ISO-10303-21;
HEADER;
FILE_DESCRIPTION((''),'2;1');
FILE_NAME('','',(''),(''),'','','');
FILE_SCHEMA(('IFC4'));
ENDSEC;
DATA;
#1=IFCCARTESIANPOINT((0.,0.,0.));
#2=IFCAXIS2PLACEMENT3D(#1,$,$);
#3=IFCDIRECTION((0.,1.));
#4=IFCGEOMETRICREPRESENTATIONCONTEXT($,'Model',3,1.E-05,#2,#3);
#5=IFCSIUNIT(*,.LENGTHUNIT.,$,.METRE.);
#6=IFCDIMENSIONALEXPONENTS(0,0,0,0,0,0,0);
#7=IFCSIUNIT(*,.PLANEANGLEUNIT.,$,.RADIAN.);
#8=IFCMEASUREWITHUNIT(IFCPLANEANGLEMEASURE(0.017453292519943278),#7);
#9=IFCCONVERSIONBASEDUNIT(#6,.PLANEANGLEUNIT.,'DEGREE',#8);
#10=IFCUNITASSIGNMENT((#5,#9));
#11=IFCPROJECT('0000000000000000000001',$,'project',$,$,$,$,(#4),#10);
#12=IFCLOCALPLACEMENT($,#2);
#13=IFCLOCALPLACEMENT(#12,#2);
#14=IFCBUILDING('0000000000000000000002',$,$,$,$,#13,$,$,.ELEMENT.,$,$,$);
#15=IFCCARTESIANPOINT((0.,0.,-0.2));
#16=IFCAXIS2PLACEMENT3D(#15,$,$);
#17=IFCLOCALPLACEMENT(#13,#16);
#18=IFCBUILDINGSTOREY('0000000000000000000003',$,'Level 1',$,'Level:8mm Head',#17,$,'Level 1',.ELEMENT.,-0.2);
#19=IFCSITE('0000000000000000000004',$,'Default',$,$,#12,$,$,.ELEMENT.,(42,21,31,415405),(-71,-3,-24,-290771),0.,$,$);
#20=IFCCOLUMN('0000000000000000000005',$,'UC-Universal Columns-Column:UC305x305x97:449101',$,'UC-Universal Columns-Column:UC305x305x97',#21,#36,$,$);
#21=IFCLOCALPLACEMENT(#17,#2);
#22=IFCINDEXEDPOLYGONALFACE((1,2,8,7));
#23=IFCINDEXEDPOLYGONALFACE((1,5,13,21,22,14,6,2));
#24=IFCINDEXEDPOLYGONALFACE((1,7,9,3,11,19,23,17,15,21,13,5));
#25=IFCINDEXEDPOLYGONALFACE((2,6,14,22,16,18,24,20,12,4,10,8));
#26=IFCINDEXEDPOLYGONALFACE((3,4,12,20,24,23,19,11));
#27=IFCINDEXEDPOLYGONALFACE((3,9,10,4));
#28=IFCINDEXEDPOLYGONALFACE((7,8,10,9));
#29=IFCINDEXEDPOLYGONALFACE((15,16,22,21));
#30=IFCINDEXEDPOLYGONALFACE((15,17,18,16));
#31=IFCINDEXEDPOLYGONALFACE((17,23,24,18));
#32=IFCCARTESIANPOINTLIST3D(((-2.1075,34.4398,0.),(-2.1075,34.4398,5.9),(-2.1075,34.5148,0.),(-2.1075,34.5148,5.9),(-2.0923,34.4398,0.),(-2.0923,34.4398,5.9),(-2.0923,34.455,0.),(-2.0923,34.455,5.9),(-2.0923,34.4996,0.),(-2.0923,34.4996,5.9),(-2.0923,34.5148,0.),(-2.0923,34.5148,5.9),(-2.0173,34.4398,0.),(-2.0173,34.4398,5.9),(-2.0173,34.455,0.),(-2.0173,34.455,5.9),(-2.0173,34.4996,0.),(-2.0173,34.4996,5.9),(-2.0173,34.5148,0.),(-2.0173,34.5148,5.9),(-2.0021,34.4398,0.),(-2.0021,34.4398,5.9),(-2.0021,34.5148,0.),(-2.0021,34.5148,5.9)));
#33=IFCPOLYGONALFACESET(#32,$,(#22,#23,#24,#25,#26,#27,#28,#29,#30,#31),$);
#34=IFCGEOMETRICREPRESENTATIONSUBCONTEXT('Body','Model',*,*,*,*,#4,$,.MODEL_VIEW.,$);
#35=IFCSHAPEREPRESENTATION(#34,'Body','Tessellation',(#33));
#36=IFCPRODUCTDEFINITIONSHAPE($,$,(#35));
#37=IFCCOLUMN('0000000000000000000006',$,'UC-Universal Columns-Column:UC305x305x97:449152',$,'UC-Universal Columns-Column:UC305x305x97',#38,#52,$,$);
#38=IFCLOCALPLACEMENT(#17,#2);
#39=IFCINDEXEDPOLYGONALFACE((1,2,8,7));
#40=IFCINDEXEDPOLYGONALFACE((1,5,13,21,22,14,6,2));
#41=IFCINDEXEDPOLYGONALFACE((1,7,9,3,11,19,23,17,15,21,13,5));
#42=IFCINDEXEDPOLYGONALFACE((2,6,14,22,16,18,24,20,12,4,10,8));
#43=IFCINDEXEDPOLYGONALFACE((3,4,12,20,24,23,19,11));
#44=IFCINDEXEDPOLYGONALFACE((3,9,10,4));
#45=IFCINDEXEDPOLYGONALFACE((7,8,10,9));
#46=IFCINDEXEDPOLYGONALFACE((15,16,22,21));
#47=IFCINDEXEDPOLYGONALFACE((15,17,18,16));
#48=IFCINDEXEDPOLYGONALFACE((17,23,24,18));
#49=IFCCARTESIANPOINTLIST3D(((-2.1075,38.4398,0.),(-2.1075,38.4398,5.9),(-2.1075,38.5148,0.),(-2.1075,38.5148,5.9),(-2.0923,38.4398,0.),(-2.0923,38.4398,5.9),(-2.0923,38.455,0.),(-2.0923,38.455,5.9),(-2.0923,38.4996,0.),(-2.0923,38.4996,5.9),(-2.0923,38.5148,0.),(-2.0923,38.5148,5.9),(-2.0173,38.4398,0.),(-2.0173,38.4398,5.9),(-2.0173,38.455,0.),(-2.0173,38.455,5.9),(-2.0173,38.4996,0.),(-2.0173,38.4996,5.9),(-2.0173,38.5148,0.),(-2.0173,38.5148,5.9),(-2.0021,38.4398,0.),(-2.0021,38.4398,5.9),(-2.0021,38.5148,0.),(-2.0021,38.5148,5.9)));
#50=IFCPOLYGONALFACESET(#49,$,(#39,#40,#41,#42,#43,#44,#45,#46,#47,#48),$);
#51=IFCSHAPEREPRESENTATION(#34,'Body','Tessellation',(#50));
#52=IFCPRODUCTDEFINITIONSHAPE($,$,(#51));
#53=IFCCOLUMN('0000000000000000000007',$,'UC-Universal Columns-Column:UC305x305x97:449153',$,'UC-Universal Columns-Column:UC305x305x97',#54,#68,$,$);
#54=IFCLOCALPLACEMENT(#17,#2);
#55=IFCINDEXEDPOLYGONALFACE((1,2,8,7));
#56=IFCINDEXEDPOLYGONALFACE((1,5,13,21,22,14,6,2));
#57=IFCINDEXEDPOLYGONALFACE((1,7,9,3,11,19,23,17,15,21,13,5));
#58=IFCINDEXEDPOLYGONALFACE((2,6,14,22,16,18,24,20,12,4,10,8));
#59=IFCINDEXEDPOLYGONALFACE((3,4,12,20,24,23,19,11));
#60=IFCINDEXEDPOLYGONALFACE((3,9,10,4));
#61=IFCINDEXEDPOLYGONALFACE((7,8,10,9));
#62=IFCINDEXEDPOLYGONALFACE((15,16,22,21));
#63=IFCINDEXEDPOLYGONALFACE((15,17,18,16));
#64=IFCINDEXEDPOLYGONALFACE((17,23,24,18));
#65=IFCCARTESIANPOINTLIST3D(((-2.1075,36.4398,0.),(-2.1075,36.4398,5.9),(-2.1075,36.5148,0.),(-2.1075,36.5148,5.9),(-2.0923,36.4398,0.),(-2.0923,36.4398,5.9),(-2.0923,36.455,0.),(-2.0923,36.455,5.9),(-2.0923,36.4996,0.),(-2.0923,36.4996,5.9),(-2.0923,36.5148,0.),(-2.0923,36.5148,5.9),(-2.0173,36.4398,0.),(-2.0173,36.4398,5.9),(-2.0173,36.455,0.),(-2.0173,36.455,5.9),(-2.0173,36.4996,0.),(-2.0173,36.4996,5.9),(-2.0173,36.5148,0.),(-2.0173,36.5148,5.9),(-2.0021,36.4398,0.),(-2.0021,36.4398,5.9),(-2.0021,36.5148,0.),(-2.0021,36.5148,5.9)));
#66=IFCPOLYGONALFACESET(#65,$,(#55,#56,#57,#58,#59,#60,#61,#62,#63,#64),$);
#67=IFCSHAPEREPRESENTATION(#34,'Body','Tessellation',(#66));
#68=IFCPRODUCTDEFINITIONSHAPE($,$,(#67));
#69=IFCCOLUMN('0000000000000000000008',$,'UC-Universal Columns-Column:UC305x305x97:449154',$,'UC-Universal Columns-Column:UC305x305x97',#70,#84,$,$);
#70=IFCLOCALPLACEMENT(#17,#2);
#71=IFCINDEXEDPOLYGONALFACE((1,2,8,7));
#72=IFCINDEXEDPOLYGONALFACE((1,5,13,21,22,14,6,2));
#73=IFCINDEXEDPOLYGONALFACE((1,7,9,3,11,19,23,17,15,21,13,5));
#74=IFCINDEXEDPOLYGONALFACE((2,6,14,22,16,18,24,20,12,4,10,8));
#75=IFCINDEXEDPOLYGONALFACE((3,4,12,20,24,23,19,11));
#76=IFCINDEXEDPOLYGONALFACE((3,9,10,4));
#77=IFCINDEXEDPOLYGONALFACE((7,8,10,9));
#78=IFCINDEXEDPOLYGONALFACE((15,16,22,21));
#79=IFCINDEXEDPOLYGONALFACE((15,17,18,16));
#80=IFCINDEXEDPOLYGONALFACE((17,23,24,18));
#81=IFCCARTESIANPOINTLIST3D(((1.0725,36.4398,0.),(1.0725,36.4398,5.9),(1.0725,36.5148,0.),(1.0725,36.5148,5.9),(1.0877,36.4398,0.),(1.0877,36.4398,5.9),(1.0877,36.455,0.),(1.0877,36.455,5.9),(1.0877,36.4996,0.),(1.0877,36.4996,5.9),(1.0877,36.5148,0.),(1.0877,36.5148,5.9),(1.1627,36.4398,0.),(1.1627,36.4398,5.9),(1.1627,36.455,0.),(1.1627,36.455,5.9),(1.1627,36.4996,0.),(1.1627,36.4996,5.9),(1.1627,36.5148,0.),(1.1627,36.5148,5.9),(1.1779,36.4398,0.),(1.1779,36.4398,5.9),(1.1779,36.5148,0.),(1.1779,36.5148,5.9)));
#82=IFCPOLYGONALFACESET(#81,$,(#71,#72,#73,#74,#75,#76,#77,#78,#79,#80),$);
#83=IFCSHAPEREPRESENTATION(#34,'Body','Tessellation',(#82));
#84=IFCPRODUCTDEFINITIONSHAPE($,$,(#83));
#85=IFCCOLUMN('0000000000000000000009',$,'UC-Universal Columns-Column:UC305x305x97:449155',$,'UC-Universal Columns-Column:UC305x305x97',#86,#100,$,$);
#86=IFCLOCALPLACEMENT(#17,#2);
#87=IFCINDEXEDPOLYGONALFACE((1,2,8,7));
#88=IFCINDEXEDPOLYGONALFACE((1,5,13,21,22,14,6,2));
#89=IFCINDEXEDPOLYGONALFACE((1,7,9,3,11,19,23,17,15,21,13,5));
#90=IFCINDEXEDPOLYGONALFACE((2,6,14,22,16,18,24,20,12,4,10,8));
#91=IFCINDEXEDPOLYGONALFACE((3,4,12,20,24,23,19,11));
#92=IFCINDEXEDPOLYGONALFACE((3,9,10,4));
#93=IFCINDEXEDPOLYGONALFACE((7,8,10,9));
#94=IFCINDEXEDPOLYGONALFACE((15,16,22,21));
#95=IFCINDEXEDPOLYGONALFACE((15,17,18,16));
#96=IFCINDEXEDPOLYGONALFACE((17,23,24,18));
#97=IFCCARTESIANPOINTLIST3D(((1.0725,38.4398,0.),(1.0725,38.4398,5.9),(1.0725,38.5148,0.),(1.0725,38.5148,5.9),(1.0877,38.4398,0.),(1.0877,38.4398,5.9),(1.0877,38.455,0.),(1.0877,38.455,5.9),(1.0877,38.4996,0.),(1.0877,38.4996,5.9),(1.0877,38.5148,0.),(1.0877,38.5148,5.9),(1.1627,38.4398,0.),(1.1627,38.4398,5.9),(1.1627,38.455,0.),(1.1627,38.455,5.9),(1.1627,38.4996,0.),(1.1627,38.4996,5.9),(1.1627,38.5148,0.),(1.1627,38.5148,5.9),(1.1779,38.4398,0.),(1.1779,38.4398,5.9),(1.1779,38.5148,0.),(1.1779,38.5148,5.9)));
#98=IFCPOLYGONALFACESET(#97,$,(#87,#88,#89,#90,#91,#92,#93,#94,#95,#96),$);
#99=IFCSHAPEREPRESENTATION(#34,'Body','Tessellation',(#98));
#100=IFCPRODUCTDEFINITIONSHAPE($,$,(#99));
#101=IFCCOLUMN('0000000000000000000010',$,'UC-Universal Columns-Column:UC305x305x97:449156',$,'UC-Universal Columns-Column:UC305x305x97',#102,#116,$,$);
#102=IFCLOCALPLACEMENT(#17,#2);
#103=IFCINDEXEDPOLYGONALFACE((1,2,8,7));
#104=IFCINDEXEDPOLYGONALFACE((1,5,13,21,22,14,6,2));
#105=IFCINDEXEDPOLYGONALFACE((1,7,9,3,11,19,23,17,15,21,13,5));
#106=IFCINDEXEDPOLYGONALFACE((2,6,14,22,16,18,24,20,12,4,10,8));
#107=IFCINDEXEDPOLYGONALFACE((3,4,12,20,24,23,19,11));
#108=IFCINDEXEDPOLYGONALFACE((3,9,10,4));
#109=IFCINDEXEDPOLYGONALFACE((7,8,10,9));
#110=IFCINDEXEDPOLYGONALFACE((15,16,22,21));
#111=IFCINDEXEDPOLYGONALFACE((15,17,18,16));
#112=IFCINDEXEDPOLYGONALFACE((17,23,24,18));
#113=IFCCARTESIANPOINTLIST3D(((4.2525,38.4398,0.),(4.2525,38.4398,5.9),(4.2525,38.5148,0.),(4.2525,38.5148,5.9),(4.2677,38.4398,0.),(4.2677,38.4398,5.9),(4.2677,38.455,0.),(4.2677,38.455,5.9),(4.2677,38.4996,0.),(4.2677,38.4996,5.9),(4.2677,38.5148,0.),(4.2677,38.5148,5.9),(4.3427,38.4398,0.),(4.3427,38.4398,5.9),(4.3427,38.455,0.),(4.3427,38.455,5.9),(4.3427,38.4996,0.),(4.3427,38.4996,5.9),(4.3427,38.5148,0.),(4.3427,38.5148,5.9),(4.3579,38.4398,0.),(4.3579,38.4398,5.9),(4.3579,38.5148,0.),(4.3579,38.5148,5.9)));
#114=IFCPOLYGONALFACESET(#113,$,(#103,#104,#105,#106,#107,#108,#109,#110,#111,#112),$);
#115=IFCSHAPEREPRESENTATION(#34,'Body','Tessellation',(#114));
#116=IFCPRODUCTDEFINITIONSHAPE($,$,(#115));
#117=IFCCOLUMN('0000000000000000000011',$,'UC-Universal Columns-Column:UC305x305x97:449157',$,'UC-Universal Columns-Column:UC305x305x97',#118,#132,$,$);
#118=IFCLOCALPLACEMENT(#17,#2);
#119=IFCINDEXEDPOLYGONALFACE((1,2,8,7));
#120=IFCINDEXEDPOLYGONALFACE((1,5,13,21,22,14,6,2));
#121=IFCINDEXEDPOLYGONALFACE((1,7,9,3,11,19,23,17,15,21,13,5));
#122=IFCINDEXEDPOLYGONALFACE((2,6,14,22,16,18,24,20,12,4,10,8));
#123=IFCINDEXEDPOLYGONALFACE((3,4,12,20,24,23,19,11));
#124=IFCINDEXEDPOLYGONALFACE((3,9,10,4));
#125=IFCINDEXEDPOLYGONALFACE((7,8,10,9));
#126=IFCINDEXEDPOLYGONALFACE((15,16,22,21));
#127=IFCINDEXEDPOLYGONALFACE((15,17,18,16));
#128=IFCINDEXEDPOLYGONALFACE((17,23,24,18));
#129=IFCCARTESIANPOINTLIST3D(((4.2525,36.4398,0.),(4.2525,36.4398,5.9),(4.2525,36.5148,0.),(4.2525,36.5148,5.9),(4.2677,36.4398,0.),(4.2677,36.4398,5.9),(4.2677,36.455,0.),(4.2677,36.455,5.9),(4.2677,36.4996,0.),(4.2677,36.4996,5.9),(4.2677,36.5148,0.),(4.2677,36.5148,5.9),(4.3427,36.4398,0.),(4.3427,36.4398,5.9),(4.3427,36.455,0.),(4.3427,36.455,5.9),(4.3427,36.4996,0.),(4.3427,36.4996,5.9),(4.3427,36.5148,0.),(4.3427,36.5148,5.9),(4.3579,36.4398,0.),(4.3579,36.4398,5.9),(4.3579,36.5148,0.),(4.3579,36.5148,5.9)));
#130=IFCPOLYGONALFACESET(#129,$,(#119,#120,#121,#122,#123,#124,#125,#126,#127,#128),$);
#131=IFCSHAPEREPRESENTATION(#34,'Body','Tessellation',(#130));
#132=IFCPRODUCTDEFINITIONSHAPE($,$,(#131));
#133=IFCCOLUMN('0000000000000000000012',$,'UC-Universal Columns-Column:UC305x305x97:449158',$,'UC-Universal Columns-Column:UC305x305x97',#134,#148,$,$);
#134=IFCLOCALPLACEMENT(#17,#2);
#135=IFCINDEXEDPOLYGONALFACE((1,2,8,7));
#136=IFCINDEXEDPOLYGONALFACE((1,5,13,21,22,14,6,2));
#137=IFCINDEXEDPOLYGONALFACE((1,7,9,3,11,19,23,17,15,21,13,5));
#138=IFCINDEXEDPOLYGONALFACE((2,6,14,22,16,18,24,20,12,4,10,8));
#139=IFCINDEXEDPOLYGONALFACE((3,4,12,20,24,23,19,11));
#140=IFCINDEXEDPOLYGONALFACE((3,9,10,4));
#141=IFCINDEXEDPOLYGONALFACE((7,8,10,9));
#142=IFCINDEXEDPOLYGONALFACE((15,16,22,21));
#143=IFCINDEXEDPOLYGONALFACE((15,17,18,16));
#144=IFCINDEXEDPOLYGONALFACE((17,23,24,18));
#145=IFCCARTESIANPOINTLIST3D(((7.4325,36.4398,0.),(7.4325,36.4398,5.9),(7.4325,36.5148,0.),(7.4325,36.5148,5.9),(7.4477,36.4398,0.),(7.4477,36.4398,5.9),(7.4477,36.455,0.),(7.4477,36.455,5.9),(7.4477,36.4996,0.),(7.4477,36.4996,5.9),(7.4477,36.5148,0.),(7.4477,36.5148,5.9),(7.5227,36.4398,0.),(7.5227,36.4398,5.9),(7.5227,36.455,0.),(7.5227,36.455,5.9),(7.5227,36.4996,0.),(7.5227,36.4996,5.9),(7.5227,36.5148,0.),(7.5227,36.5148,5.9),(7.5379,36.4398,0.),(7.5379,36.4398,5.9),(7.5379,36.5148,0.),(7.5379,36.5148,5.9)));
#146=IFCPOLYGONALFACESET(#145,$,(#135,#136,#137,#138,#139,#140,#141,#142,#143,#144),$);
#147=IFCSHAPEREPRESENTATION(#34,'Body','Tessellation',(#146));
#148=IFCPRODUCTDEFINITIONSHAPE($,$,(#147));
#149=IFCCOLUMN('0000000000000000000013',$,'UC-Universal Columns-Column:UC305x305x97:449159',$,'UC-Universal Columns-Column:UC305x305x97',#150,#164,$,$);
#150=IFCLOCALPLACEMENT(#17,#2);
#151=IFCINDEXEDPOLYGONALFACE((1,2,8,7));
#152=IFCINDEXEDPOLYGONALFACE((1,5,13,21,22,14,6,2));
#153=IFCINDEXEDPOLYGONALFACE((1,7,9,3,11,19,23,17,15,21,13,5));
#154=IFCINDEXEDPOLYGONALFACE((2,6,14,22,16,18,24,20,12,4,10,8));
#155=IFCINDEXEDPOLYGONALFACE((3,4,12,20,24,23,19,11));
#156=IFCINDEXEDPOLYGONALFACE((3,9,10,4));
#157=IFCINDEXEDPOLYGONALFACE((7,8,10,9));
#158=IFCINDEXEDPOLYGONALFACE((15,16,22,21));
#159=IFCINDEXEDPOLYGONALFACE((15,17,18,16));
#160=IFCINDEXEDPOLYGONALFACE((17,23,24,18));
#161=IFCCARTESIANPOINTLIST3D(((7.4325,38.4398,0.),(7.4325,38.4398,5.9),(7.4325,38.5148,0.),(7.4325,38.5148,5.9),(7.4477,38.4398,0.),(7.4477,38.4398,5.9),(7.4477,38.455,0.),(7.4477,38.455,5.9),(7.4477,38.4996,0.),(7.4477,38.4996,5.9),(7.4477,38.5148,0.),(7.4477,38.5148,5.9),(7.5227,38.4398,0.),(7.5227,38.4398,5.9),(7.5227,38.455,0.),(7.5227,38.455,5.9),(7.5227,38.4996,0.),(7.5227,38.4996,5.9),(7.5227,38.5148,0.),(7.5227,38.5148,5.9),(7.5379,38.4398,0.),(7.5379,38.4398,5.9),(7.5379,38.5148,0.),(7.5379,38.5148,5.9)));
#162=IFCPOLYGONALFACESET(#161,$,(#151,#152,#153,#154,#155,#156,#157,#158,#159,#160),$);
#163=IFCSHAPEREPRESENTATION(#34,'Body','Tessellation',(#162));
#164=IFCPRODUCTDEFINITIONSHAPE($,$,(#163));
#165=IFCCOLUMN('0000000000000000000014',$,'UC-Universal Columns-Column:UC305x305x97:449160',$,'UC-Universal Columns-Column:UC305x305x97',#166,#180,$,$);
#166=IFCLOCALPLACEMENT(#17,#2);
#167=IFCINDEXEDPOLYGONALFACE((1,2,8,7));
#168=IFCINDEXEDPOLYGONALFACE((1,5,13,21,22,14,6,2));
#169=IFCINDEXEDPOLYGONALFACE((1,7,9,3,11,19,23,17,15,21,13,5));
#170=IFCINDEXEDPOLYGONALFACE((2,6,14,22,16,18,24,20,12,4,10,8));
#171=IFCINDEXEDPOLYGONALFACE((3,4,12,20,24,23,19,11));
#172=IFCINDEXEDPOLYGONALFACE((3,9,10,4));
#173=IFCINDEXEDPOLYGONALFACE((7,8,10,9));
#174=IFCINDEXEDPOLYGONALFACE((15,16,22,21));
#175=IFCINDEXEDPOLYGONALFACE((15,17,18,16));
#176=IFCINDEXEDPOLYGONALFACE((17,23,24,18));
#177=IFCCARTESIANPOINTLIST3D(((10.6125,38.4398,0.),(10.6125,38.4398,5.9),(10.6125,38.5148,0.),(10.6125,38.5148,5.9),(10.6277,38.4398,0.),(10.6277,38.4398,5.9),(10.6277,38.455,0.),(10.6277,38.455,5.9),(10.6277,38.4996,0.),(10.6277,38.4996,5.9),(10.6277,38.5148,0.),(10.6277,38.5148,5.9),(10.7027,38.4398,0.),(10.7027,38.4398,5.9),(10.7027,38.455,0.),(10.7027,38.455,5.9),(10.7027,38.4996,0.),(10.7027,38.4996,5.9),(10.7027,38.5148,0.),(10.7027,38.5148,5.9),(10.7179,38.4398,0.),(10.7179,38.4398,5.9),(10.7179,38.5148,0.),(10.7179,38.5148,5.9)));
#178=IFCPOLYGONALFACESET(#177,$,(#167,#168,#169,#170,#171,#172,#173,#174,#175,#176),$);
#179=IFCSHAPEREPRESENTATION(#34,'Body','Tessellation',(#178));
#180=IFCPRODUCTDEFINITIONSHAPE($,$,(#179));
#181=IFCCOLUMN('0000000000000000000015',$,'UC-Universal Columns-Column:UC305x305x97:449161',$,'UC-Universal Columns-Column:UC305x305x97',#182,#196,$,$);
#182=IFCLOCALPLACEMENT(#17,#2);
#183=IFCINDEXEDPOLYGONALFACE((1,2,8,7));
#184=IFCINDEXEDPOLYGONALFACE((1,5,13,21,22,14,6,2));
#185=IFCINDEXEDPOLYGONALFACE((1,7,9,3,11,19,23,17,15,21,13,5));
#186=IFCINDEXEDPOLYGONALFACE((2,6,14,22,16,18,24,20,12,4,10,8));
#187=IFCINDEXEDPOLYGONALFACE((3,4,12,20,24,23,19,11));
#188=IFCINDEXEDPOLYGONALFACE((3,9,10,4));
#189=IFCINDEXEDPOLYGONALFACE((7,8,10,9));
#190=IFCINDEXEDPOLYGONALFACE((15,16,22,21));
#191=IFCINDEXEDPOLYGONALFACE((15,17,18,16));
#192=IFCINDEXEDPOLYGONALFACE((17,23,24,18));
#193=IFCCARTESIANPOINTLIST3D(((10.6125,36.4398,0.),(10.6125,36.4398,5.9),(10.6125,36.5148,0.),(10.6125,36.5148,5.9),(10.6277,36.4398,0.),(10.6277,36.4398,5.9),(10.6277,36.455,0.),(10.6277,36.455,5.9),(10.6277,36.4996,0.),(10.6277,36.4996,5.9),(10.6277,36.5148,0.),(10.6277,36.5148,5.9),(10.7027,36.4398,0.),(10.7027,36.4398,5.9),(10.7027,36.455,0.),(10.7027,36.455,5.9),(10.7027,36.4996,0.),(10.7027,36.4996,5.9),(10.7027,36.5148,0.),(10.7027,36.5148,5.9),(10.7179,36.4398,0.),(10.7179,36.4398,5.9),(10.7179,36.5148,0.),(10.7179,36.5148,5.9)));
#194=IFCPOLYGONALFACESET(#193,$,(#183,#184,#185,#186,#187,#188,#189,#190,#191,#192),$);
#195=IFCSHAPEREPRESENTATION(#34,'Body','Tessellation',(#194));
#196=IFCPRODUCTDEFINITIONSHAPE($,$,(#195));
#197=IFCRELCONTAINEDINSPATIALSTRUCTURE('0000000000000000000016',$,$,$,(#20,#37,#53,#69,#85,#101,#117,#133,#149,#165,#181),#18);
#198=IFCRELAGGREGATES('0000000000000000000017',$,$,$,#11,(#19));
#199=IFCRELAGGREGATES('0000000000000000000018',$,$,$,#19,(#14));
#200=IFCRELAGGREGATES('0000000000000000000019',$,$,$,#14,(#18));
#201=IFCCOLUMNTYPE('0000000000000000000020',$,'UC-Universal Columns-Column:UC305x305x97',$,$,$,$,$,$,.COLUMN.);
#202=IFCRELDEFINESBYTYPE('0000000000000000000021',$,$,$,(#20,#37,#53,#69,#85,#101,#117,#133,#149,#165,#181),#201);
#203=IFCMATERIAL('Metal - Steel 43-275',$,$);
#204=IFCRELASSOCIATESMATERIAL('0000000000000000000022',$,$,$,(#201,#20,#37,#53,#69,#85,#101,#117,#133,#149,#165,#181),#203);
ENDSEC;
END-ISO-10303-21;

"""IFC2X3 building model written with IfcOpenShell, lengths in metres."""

from ifc_helpers import new_model, entity, si_unit, converted_unit, direction, frame, frame_2d, origin, place, context, subcontext, project, spatial, polyline, circle_curve, parameter, trimmed, segment, composite_curve, outline, extrude, source, transform, mapped, material, type_object, type_shapes, element, save


model = new_model("IFC2X3")

# Units and contexts
model_context = context("Model", 3, precision=1e-05, world=origin(), true_north=direction((0.0, 1.0)))
body_context = subcontext(model_context, "Body", "Model", "MODEL_VIEW")
ifc_project = project(units=[si_unit("LENGTHUNIT", "METRE"), converted_unit("PLANEANGLEUNIT", "DEGREE", entity("IfcPlaneAngleMeasure", 0.017453292519943278), si_unit("PLANEANGLEUNIT", "RADIAN"), dimensions=[0, 0, 0, 0, 0, 0, 0])], contexts=[model_context])

# Site, building, storey
site_placement = place(None, origin())
site = spatial("IfcSite", under=ifc_project, at=site_placement, Name="Default", CompositionType="ELEMENT", RefLatitude=(42, 21, 31, 415405), RefLongitude=(-71, -3, -24, -290771), RefElevation=0.0)
building_placement = place(site_placement, origin())
building = spatial("IfcBuilding", under=site, at=building_placement, CompositionType="ELEMENT")
storey_placement = place(building_placement, frame((0.0, 0.0, -0.2)))
storey = spatial("IfcBuildingStorey", under=building, at=storey_placement, Name="Level 1", ObjectType="Level:8mm Head", LongName="Level 1", CompositionType="ELEMENT", Elevation=-0.2)

# Columns
ifc_material = material(Name="Metal - Steel 43-275")
column_type = type_object("IfcColumnType", Name="UC-Universal Columns-Column:UC305x305x97", PredefinedType="COLUMN", material=ifc_material)
shared_shape = source(origin(), body_context, "Body", "SweptSolid", [
    extrude(outline(composite_curve([segment(polyline([(-0.0375, -0.0375), (0.0375, -0.0375)]), True, "CONTINUOUS"), segment(polyline([(0.0375, -0.0375), (0.0527, -0.0375)]), True, "CONTINUOUS"), segment(trimmed(circle_curve(frame_2d((0.0527, -0.0223), x_axis=(-1.0, 0.0)), 0.0152), [parameter(0.0)], [parameter(90.0)], True, "PARAMETER"), False, "CONTINUOUS"), segment(polyline([(0.0375, -0.0223), (0.0375, 0.0223)]), True, "CONTINUOUS"), segment(trimmed(circle_curve(frame_2d((0.0527, 0.0223), x_axis=(-1.0, 0.0)), 0.0152), [parameter(270.0)], [parameter(0.0)], True, "PARAMETER"), False, "CONTINUOUS"), segment(polyline([(0.0527, 0.0375), (0.0375, 0.0375)]), True, "CONTINUOUS"), segment(polyline([(0.0375, 0.0375), (-0.0375, 0.0375)]), True, "CONTINUOUS"), segment(polyline([(-0.0375, 0.0375), (-0.0527, 0.0375)]), True, "CONTINUOUS"), segment(trimmed(circle_curve(frame_2d((-0.0527, 0.0223), x_axis=(-1.0, 0.0)), 0.0152), [parameter(180.0)], [parameter(270.0)], True, "PARAMETER"), False, "CONTINUOUS"), segment(polyline([(-0.0375, 0.0223), (-0.0375, -0.0223)]), True, "CONTINUOUS"), segment(trimmed(circle_curve(frame_2d((-0.0527, -0.0223), x_axis=(-1.0, 0.0)), 0.0152), [parameter(90.0)], [parameter(180.0)], True, "PARAMETER"), False, "CONTINUOUS"), segment(polyline([(-0.0527, -0.0375), (-0.0375, -0.0375)]), True, "CONTINUOUS")], self_intersect=False)), frame((0.0, 0.0, -0.2), z_axis=(0.0, 0.0, 1.0), x_axis=(-1.0, 0.0, 0.0)), (0.0, 0.0, 1.0), 5.9),
])
type_shapes(column_type, [shared_shape])
for number, where, z_axis, x_axis, name in (
    (1, (-2.0548, 34.4773, 0.2), (0.0, 0.0, 1.0), (-1.0, 0.0, 0.0), "UC-Universal Columns-Column:UC305x305x97:449101"),
    (2, (-2.0548, 38.4773, 0.2), (0.0, 0.0, 1.0), (-1.0, 0.0, 0.0), "UC-Universal Columns-Column:UC305x305x97:449152"),
    (3, (-2.0548, 36.4773, 0.2), (0.0, 0.0, 1.0), (-1.0, 0.0, 0.0), "UC-Universal Columns-Column:UC305x305x97:449153"),
    (4, (1.1252, 36.4773, 0.2), (0.0, 0.0, 1.0), (-1.0, 0.0, 0.0), "UC-Universal Columns-Column:UC305x305x97:449154"),
    (5, (1.1252, 38.4773, 0.2), (0.0, 0.0, 1.0), (-1.0, 0.0, 0.0), "UC-Universal Columns-Column:UC305x305x97:449155"),
    (6, (4.3052, 38.4773, 0.2), (0.0, 0.0, 1.0), (-1.0, 0.0, 0.0), "UC-Universal Columns-Column:UC305x305x97:449156"),
    (7, (4.3052, 36.4773, 0.2), (0.0, 0.0, 1.0), (-1.0, 0.0, 0.0), "UC-Universal Columns-Column:UC305x305x97:449157"),
    (8, (7.4852, 36.4773, 0.2), (0.0, 0.0, 1.0), (-1.0, 0.0, 0.0), "UC-Universal Columns-Column:UC305x305x97:449158"),
    (9, (7.4852, 38.4773, 0.2), (0.0, 0.0, 1.0), (-1.0, 0.0, 0.0), "UC-Universal Columns-Column:UC305x305x97:449159"),
    (10, (10.6652, 38.4773, 0.2), (0.0, 0.0, 1.0), (-1.0, 0.0, 0.0), "UC-Universal Columns-Column:UC305x305x97:449160"),
    (11, (10.6652, 36.4773, 0.2), (0.0, 0.0, 1.0), (-1.0, 0.0, 0.0), "UC-Universal Columns-Column:UC305x305x97:449161"),
):
    element("IfcColumn", number, at=place(storey_placement, frame(where, z_axis=z_axis, x_axis=x_axis)), inside=storey, type_object=column_type, material=ifc_material, Name=name, ObjectType="UC-Universal Columns-Column:UC305x305x97", context=body_context, shape_type="MappedRepresentation", body=[
        mapped(shared_shape, transform((0.0, 0.0, 0.0), scale=1.0)),
    ])

save(model, "model.ifc")
